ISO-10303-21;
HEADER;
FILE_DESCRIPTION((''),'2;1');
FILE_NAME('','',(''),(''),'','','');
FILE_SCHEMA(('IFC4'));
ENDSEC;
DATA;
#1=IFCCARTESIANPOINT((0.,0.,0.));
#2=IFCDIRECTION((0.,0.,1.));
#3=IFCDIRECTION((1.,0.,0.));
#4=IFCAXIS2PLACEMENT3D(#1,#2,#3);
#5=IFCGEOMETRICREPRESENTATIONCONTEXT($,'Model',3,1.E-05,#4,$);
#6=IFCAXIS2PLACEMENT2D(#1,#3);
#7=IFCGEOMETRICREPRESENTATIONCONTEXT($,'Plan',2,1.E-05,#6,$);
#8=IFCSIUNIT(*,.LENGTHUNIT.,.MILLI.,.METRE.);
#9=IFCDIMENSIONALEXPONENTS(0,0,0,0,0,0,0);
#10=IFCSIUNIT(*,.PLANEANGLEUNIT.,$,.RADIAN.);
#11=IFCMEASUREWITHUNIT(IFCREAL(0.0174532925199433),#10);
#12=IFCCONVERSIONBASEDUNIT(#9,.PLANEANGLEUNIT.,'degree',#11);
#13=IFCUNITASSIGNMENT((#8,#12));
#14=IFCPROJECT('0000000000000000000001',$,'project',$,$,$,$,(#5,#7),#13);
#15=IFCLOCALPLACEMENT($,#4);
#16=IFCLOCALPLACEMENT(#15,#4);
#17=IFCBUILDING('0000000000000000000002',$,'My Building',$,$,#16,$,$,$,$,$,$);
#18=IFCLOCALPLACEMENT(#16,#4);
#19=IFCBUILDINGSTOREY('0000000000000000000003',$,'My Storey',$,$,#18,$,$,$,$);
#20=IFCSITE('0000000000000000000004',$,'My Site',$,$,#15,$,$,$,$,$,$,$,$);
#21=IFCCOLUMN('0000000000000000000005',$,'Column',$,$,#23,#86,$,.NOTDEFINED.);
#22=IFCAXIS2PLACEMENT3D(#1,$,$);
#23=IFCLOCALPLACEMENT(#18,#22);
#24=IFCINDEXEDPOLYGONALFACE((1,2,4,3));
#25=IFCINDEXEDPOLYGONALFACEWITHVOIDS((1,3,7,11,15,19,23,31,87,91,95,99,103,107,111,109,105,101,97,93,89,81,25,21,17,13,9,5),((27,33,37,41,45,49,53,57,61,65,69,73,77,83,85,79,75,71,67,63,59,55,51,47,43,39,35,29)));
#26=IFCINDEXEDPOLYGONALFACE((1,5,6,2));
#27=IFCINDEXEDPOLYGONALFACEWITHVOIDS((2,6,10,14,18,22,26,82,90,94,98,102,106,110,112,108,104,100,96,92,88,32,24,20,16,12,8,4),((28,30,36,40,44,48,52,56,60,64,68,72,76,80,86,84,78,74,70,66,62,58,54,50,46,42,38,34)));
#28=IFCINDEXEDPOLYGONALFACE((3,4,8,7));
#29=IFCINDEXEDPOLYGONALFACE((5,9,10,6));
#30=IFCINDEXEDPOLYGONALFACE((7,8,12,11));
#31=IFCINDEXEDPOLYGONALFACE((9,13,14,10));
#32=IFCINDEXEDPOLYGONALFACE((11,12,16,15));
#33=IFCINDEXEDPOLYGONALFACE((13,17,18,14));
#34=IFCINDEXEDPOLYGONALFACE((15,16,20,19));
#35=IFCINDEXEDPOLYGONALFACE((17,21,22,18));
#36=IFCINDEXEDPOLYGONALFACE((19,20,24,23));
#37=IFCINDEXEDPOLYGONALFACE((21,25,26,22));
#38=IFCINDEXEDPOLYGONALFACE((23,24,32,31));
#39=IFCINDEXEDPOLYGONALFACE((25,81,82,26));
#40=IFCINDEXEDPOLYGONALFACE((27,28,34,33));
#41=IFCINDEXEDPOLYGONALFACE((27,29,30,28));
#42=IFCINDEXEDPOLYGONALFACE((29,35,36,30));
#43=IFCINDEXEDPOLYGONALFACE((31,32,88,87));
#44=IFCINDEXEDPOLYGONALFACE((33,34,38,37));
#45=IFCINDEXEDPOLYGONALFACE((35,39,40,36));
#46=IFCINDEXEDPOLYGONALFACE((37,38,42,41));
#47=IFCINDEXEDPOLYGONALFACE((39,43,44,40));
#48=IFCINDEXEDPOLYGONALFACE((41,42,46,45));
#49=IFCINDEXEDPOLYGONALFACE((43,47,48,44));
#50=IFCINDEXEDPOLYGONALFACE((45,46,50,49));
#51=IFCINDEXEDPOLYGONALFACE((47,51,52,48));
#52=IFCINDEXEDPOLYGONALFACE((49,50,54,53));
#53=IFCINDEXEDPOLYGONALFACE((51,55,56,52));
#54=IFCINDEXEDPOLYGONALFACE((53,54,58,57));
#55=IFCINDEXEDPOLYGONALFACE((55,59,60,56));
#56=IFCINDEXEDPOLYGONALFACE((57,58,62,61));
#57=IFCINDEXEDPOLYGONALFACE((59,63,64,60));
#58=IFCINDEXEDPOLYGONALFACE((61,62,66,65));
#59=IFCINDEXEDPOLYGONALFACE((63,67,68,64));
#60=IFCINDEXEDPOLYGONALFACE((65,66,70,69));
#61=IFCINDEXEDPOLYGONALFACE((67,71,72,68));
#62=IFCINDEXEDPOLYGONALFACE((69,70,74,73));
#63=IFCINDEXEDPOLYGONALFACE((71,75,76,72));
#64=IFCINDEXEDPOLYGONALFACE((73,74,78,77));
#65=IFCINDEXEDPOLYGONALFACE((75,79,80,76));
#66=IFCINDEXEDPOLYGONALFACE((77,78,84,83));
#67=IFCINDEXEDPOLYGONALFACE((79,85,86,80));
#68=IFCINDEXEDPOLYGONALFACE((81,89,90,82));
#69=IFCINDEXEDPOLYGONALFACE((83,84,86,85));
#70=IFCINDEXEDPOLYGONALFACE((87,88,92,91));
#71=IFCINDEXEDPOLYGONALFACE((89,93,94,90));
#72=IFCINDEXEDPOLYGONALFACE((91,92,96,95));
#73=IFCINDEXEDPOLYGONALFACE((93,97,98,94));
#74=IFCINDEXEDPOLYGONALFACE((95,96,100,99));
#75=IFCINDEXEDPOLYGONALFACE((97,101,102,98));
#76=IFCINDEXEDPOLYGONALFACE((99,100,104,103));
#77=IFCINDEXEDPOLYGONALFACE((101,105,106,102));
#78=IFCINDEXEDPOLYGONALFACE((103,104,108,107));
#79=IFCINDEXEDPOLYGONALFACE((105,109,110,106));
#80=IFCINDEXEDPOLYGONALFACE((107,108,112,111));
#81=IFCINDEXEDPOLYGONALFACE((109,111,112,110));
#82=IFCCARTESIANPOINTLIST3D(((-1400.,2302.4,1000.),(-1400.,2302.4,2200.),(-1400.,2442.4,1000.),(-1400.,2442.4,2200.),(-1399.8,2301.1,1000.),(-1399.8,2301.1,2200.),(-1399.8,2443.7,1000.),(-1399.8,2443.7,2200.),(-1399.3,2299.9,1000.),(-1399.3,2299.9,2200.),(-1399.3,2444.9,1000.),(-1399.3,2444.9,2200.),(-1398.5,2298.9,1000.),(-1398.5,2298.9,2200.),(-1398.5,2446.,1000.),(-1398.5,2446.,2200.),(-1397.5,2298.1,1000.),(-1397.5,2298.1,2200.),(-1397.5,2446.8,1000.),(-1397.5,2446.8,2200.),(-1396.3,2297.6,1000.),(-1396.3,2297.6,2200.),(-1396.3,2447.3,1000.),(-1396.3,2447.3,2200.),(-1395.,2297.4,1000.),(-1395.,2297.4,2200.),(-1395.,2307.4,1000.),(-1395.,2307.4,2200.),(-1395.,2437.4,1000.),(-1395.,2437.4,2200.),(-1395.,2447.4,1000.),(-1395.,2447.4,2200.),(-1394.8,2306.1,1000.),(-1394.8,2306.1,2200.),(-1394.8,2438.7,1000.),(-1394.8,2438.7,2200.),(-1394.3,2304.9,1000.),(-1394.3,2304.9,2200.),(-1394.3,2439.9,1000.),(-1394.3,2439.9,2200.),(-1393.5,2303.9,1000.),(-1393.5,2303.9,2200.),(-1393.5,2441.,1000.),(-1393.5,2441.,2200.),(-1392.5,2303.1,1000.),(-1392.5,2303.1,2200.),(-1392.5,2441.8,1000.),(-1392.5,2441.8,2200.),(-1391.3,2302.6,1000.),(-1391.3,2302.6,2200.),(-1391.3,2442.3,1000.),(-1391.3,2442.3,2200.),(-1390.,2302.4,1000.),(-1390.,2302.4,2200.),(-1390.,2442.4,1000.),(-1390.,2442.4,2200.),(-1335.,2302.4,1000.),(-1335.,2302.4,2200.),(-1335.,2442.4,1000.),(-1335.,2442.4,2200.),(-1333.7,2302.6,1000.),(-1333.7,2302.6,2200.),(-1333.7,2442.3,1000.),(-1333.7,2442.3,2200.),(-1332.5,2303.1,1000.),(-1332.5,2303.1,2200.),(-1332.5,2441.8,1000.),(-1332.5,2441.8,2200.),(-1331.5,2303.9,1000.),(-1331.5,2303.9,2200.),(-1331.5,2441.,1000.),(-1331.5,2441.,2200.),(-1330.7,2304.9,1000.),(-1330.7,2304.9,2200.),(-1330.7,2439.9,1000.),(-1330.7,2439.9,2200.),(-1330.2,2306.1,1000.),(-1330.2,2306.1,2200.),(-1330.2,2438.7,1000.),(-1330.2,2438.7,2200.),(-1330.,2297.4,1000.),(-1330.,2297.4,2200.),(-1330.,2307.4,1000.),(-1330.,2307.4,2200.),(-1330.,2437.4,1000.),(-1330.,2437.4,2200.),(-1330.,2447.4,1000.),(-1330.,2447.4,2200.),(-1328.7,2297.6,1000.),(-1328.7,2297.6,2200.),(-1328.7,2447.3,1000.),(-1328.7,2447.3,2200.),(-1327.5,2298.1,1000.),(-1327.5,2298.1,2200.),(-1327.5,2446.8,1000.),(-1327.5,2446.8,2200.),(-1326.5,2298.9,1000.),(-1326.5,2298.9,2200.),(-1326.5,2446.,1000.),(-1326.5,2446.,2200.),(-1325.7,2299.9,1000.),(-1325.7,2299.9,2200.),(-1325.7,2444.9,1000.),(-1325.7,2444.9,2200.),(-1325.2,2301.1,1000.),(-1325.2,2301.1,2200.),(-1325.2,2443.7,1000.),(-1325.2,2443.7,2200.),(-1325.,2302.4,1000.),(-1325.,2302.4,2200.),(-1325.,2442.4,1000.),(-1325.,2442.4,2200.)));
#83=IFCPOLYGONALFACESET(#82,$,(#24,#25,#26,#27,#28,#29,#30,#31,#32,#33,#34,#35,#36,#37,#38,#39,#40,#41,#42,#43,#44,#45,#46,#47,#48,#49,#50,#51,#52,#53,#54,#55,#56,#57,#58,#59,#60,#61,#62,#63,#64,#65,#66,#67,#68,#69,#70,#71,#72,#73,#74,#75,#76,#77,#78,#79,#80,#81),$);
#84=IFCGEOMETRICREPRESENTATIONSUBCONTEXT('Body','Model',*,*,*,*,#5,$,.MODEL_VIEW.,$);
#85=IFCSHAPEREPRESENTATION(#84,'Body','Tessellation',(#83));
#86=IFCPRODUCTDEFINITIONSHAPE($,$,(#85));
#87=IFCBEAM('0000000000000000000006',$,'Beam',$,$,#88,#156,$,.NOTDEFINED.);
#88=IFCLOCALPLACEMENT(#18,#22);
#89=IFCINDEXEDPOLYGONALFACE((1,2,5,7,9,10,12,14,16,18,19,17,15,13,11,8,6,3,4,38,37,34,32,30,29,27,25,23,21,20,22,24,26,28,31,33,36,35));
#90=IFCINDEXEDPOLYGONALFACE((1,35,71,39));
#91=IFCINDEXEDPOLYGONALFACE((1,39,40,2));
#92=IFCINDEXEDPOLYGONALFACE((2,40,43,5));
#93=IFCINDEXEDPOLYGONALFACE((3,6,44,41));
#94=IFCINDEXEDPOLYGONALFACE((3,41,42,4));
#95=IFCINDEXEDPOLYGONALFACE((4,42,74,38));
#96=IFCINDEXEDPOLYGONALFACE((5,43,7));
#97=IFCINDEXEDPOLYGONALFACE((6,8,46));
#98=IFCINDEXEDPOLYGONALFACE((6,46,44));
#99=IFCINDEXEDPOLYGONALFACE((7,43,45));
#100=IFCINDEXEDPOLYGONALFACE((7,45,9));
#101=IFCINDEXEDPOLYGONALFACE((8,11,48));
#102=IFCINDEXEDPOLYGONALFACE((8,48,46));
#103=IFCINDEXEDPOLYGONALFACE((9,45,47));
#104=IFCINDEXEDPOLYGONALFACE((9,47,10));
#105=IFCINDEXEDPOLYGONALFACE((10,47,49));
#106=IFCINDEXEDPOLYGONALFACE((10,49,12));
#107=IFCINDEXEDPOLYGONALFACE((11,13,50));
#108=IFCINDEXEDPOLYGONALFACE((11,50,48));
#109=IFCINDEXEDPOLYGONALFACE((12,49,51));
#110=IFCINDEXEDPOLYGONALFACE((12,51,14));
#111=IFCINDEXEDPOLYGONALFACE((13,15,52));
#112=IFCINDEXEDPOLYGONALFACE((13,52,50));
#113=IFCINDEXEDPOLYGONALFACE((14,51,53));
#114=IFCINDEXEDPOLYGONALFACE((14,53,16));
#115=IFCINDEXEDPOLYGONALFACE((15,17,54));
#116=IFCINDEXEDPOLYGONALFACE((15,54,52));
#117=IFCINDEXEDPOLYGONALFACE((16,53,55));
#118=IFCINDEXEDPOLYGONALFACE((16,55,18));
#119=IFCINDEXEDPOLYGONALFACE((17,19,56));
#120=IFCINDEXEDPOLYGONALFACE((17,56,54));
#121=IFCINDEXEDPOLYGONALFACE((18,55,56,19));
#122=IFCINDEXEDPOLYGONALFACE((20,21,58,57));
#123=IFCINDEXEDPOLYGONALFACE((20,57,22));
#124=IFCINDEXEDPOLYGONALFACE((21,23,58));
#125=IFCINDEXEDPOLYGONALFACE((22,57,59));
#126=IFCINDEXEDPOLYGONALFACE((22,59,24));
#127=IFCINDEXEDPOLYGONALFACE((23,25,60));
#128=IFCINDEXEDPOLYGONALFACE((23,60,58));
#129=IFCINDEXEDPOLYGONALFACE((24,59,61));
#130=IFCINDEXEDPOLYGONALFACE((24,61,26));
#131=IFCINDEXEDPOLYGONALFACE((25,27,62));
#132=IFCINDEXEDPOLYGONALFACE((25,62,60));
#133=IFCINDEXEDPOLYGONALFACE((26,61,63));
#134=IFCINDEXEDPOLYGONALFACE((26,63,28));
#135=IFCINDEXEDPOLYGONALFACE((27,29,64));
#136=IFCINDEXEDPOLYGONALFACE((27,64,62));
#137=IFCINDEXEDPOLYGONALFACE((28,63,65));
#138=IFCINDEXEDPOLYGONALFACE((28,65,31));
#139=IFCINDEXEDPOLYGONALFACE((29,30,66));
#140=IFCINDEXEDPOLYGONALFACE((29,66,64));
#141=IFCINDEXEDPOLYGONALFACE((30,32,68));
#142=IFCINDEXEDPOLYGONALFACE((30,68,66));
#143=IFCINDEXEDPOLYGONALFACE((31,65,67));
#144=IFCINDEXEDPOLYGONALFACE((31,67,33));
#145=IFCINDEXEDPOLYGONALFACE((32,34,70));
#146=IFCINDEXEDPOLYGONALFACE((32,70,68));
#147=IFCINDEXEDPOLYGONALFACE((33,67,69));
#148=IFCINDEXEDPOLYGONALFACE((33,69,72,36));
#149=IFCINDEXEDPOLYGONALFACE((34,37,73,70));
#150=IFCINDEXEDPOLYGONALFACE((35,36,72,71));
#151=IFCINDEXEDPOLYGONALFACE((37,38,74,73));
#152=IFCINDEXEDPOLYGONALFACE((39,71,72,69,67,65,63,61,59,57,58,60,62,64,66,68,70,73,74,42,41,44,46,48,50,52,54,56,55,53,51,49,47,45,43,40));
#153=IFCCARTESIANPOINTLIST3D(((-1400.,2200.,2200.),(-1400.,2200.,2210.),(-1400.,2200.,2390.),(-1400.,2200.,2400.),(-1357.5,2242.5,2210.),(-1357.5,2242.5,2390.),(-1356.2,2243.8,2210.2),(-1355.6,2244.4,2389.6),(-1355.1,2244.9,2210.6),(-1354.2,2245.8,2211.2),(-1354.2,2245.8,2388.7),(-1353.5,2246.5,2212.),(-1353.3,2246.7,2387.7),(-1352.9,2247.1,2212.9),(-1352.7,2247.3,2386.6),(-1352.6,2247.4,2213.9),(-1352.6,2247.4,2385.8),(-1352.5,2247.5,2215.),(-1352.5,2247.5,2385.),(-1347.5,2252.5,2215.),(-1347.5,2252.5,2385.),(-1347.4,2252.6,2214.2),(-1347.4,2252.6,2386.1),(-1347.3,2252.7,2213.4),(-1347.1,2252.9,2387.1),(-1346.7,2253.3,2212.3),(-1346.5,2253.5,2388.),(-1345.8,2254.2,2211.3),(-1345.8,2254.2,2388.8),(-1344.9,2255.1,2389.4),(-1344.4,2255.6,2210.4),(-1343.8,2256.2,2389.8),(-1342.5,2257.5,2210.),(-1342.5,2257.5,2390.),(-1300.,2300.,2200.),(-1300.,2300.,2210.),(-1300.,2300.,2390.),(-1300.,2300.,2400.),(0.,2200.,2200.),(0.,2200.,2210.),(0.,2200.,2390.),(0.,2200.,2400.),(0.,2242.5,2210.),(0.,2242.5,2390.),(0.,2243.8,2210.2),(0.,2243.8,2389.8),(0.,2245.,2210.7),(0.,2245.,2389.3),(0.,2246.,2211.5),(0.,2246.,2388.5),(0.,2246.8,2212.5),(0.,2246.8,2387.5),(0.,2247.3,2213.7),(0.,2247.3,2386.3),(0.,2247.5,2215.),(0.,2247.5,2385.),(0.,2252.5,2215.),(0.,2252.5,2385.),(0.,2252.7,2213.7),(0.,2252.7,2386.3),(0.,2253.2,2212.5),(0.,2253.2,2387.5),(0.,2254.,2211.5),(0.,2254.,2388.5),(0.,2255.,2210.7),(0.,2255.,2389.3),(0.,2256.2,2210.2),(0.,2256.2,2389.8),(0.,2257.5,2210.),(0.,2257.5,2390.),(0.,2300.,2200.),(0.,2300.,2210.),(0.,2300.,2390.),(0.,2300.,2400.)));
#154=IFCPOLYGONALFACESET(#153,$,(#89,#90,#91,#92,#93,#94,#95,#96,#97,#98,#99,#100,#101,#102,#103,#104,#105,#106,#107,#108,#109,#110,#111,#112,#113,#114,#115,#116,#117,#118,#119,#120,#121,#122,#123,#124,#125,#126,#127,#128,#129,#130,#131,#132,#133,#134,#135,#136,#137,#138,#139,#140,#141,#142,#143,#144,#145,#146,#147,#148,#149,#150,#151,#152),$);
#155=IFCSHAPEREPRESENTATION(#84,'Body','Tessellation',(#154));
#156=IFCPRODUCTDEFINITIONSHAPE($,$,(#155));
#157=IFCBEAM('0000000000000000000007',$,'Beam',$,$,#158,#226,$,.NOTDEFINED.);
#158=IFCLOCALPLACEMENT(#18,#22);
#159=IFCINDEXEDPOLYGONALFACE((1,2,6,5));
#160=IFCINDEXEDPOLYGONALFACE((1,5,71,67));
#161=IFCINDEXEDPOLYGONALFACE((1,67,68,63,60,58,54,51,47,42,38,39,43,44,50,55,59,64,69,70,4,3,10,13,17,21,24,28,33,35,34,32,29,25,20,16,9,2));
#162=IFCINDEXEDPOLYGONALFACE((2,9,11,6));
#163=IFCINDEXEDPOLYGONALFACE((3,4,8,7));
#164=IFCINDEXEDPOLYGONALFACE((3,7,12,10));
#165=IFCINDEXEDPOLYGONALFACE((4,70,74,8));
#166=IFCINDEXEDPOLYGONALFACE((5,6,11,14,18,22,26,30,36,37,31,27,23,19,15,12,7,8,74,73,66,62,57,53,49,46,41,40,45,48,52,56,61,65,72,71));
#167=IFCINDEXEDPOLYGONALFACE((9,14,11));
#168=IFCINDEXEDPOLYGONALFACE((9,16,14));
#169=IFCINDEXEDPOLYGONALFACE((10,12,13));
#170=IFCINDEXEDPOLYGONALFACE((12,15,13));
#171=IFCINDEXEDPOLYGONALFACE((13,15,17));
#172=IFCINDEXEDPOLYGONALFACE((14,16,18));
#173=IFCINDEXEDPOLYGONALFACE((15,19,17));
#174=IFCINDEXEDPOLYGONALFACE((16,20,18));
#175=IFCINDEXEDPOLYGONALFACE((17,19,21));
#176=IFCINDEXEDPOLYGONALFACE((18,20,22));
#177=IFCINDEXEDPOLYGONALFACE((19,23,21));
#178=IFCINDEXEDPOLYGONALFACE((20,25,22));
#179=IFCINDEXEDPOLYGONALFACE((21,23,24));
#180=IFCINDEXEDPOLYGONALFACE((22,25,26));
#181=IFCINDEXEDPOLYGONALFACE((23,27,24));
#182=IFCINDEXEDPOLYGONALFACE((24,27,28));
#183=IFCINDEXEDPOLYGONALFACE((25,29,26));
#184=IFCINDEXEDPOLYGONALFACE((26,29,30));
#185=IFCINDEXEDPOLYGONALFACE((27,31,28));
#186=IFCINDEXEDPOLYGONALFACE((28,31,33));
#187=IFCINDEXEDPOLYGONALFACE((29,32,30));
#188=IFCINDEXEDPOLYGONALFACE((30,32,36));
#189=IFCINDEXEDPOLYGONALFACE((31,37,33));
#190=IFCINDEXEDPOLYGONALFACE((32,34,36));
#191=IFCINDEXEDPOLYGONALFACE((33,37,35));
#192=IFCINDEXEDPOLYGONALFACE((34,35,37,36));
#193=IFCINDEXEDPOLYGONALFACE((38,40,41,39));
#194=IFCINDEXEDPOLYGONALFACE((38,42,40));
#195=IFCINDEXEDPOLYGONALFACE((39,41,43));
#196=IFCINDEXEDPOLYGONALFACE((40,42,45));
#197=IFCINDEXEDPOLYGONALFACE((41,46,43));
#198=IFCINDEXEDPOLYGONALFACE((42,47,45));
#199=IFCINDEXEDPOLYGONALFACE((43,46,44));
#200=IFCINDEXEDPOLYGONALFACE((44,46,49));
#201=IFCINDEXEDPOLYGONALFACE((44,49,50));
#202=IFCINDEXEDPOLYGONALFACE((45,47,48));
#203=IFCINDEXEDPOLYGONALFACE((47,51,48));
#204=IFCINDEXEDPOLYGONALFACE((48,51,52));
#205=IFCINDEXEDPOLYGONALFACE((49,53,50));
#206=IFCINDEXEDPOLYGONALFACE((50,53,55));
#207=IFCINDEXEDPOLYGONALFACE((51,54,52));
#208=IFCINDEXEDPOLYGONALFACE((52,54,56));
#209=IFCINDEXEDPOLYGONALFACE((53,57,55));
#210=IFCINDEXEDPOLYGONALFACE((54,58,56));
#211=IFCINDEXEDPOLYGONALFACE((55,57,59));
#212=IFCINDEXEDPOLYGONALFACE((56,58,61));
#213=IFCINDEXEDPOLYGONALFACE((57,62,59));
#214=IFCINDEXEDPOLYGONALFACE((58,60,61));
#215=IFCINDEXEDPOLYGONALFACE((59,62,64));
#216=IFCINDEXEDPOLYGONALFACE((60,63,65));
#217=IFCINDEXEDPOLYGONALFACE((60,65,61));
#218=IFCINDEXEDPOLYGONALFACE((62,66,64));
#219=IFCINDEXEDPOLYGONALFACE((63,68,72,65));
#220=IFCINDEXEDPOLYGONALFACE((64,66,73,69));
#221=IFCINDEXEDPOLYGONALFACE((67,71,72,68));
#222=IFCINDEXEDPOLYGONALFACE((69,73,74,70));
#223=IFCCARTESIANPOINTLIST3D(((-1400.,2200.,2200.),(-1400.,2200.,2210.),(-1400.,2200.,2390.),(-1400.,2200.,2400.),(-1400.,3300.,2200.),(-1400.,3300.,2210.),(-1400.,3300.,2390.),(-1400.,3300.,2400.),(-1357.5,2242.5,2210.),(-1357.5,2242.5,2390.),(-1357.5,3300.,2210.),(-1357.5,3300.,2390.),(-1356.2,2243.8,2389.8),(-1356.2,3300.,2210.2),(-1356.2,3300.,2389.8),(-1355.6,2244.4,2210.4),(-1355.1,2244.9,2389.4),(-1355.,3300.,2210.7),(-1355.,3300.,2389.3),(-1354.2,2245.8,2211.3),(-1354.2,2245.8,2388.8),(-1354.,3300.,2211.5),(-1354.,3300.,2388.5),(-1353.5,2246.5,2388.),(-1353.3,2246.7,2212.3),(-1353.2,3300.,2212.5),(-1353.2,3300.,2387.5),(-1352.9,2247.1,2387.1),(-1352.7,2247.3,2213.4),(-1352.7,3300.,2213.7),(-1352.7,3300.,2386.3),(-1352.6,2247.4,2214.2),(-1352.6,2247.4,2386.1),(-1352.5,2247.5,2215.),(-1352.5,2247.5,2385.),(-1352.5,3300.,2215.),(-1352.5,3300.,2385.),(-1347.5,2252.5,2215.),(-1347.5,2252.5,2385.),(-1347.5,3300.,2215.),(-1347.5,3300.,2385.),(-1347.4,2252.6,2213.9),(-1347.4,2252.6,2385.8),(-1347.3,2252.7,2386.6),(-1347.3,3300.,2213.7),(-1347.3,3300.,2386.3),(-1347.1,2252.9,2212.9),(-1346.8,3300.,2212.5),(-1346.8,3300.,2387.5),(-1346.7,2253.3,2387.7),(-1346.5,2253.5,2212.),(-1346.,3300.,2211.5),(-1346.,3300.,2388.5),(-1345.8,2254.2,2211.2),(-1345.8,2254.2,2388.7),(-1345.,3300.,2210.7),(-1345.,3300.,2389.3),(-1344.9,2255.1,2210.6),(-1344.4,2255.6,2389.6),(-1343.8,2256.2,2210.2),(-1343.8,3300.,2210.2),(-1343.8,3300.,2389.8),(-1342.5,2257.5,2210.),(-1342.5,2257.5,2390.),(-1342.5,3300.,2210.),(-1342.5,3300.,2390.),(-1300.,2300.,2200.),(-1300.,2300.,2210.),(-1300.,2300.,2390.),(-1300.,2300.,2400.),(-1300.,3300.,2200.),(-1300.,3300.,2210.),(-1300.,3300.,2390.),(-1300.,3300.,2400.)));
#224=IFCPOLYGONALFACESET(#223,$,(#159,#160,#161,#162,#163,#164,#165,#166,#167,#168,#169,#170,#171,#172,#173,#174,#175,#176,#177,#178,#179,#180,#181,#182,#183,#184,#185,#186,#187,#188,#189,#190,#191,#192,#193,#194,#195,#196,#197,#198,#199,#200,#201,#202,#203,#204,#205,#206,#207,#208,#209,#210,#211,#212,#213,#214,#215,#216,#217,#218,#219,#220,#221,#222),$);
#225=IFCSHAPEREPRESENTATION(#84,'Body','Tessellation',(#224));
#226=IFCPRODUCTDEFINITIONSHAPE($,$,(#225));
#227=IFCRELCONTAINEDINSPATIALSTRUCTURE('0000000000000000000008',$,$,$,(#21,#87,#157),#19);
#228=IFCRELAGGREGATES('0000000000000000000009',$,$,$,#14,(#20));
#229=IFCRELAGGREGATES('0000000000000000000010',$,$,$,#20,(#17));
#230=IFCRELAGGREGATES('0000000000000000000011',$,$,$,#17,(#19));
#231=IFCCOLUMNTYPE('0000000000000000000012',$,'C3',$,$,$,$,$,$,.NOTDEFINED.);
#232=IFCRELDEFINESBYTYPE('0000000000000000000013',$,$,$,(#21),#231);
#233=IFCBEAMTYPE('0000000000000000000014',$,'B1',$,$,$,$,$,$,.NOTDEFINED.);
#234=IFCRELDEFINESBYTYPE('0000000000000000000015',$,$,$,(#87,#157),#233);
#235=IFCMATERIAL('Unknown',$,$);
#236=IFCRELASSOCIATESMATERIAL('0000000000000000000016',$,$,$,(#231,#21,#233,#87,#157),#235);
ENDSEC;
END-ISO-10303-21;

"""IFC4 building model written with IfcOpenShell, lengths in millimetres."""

from ifc_helpers import new_model, entity, si_unit, converted_unit, frame, frame_2d, origin_with_axes, place, context, subcontext, project, spatial, hollow_rectangle, i_section, extrude, clip, halfspace, material, material_profile, profile_set, profile_usage, type_object, element, save


model = new_model("IFC4")

# Units and contexts
model_context = context("Model", 3, precision=1e-05, world=origin_with_axes())
plan_context = context("Plan", 2, precision=1e-05, world=frame_2d((0.0, 0.0, 0.0), x_axis=(1.0, 0.0, 0.0)))
body_context = subcontext(model_context, "Body", "Model", "MODEL_VIEW")
ifc_project = project(units=[si_unit("LENGTHUNIT", "METRE", prefix="MILLI"), converted_unit("PLANEANGLEUNIT", "degree", entity("IfcReal", 0.0174532925199433), si_unit("PLANEANGLEUNIT", "RADIAN"), dimensions=[0, 0, 0, 0, 0, 0, 0])], contexts=[model_context, plan_context])

# Site, building, storey
site_placement = place(None, origin_with_axes())
site = spatial("IfcSite", under=ifc_project, at=site_placement, Name="My Site")
building_placement = place(site_placement, origin_with_axes())
building = spatial("IfcBuilding", under=site, at=building_placement, Name="My Building")
storey_placement = place(building_placement, origin_with_axes())
storey = spatial("IfcBuildingStorey", under=building, at=storey_placement, Name="My Storey")

# Column
ifc_material = material(Name="Unknown")
ifc_material_profile_1 = material_profile(ifc_material, hollow_rectangle(XDim=75.0, YDim=150.0, WallThickness=5.0, InnerFilletRadius=5.0, OuterFilletRadius=5.0))
ifc_profile_set_1 = profile_set([ifc_material_profile_1])
ifc_profile_usage_1 = profile_usage(ifc_profile_set_1, cardinal=5)
column_type = type_object("IfcColumnType", Name="C3", PredefinedType="NOTDEFINED", material=ifc_profile_set_1)
column_placement = place(storey_placement, frame((-1362.5, 2372.4, 1000.0), z_axis=(0.0, 0.0, 1.0), x_axis=(1.0, 0.0, 0.0)))
element("IfcColumn", 1, at=column_placement, inside=storey, type_object=column_type, material=ifc_profile_usage_1, Name="Column", PredefinedType="NOTDEFINED", context=body_context, shape_type="SweptSolid", body=[
    extrude(hollow_rectangle(XDim=75.0, YDim=150.0, WallThickness=5.0, InnerFilletRadius=5.0, OuterFilletRadius=5.0), origin_with_axes(), (0.0, 0.0, 1.0), 1200.0),
])

# Beams
ifc_material_profile_2 = material_profile(ifc_material, i_section(OverallWidth=100.0, OverallDepth=200.0, WebThickness=5.0, FlangeThickness=10.0, FilletRadius=5.0))
ifc_profile_set_2 = profile_set([ifc_material_profile_2])
ifc_profile_usage_2 = profile_usage(ifc_profile_set_2, cardinal=5)
beam_type_1 = type_object("IfcBeamType", Name="B1", PredefinedType="NOTDEFINED", material=ifc_profile_set_2)
beam_1_placement = place(storey_placement, frame((-1400.0, 2250.0, 2300.0), z_axis=(1.0, 0.0, 0.0), x_axis=(0.0, 1.0, 0.0)))
element("IfcBeam", 2, at=beam_1_placement, inside=storey, type_object=beam_type_1, material=ifc_profile_usage_2, Name="Beam", PredefinedType="NOTDEFINED", context=body_context, shape_type="Clipping", body=[
    clip(extrude(i_section(OverallWidth=100.0, OverallDepth=200.0, WebThickness=5.0, FlangeThickness=10.0, FilletRadius=5.0), origin_with_axes(), (0.0, 0.0, 1.0), 1400.0), halfspace(frame((-50.0, -2350.0, 0.0), z_axis=(0.707107, 0.0, -0.707107), x_axis=(0.707107, 0.0, 0.707107)), False)),
])
ifc_profile_usage_3 = profile_usage(ifc_profile_set_2, cardinal=5)
beam_2_placement = place(storey_placement, frame((-1350.0, 2200.0, 2300.0), z_axis=(0.0, 1.0, 0.0), x_axis=(-1.0, 0.0, 0.0)))
element("IfcBeam", 3, at=beam_2_placement, inside=storey, type_object=beam_type_1, material=ifc_profile_usage_3, Name="Beam", PredefinedType="NOTDEFINED", context=body_context, shape_type="Clipping", body=[
    clip(extrude(i_section(OverallWidth=100.0, OverallDepth=200.0, WebThickness=5.0, FlangeThickness=10.0, FilletRadius=5.0), origin_with_axes(), (0.0, 0.0, 1.0), 1100.0), halfspace(frame((50.0, -2350.0, 0.0), z_axis=(-0.707107, 0.0, -0.707107), x_axis=(-0.707107, 0.0, 0.707107)), False)),
])

save(model, "model.ifc")
